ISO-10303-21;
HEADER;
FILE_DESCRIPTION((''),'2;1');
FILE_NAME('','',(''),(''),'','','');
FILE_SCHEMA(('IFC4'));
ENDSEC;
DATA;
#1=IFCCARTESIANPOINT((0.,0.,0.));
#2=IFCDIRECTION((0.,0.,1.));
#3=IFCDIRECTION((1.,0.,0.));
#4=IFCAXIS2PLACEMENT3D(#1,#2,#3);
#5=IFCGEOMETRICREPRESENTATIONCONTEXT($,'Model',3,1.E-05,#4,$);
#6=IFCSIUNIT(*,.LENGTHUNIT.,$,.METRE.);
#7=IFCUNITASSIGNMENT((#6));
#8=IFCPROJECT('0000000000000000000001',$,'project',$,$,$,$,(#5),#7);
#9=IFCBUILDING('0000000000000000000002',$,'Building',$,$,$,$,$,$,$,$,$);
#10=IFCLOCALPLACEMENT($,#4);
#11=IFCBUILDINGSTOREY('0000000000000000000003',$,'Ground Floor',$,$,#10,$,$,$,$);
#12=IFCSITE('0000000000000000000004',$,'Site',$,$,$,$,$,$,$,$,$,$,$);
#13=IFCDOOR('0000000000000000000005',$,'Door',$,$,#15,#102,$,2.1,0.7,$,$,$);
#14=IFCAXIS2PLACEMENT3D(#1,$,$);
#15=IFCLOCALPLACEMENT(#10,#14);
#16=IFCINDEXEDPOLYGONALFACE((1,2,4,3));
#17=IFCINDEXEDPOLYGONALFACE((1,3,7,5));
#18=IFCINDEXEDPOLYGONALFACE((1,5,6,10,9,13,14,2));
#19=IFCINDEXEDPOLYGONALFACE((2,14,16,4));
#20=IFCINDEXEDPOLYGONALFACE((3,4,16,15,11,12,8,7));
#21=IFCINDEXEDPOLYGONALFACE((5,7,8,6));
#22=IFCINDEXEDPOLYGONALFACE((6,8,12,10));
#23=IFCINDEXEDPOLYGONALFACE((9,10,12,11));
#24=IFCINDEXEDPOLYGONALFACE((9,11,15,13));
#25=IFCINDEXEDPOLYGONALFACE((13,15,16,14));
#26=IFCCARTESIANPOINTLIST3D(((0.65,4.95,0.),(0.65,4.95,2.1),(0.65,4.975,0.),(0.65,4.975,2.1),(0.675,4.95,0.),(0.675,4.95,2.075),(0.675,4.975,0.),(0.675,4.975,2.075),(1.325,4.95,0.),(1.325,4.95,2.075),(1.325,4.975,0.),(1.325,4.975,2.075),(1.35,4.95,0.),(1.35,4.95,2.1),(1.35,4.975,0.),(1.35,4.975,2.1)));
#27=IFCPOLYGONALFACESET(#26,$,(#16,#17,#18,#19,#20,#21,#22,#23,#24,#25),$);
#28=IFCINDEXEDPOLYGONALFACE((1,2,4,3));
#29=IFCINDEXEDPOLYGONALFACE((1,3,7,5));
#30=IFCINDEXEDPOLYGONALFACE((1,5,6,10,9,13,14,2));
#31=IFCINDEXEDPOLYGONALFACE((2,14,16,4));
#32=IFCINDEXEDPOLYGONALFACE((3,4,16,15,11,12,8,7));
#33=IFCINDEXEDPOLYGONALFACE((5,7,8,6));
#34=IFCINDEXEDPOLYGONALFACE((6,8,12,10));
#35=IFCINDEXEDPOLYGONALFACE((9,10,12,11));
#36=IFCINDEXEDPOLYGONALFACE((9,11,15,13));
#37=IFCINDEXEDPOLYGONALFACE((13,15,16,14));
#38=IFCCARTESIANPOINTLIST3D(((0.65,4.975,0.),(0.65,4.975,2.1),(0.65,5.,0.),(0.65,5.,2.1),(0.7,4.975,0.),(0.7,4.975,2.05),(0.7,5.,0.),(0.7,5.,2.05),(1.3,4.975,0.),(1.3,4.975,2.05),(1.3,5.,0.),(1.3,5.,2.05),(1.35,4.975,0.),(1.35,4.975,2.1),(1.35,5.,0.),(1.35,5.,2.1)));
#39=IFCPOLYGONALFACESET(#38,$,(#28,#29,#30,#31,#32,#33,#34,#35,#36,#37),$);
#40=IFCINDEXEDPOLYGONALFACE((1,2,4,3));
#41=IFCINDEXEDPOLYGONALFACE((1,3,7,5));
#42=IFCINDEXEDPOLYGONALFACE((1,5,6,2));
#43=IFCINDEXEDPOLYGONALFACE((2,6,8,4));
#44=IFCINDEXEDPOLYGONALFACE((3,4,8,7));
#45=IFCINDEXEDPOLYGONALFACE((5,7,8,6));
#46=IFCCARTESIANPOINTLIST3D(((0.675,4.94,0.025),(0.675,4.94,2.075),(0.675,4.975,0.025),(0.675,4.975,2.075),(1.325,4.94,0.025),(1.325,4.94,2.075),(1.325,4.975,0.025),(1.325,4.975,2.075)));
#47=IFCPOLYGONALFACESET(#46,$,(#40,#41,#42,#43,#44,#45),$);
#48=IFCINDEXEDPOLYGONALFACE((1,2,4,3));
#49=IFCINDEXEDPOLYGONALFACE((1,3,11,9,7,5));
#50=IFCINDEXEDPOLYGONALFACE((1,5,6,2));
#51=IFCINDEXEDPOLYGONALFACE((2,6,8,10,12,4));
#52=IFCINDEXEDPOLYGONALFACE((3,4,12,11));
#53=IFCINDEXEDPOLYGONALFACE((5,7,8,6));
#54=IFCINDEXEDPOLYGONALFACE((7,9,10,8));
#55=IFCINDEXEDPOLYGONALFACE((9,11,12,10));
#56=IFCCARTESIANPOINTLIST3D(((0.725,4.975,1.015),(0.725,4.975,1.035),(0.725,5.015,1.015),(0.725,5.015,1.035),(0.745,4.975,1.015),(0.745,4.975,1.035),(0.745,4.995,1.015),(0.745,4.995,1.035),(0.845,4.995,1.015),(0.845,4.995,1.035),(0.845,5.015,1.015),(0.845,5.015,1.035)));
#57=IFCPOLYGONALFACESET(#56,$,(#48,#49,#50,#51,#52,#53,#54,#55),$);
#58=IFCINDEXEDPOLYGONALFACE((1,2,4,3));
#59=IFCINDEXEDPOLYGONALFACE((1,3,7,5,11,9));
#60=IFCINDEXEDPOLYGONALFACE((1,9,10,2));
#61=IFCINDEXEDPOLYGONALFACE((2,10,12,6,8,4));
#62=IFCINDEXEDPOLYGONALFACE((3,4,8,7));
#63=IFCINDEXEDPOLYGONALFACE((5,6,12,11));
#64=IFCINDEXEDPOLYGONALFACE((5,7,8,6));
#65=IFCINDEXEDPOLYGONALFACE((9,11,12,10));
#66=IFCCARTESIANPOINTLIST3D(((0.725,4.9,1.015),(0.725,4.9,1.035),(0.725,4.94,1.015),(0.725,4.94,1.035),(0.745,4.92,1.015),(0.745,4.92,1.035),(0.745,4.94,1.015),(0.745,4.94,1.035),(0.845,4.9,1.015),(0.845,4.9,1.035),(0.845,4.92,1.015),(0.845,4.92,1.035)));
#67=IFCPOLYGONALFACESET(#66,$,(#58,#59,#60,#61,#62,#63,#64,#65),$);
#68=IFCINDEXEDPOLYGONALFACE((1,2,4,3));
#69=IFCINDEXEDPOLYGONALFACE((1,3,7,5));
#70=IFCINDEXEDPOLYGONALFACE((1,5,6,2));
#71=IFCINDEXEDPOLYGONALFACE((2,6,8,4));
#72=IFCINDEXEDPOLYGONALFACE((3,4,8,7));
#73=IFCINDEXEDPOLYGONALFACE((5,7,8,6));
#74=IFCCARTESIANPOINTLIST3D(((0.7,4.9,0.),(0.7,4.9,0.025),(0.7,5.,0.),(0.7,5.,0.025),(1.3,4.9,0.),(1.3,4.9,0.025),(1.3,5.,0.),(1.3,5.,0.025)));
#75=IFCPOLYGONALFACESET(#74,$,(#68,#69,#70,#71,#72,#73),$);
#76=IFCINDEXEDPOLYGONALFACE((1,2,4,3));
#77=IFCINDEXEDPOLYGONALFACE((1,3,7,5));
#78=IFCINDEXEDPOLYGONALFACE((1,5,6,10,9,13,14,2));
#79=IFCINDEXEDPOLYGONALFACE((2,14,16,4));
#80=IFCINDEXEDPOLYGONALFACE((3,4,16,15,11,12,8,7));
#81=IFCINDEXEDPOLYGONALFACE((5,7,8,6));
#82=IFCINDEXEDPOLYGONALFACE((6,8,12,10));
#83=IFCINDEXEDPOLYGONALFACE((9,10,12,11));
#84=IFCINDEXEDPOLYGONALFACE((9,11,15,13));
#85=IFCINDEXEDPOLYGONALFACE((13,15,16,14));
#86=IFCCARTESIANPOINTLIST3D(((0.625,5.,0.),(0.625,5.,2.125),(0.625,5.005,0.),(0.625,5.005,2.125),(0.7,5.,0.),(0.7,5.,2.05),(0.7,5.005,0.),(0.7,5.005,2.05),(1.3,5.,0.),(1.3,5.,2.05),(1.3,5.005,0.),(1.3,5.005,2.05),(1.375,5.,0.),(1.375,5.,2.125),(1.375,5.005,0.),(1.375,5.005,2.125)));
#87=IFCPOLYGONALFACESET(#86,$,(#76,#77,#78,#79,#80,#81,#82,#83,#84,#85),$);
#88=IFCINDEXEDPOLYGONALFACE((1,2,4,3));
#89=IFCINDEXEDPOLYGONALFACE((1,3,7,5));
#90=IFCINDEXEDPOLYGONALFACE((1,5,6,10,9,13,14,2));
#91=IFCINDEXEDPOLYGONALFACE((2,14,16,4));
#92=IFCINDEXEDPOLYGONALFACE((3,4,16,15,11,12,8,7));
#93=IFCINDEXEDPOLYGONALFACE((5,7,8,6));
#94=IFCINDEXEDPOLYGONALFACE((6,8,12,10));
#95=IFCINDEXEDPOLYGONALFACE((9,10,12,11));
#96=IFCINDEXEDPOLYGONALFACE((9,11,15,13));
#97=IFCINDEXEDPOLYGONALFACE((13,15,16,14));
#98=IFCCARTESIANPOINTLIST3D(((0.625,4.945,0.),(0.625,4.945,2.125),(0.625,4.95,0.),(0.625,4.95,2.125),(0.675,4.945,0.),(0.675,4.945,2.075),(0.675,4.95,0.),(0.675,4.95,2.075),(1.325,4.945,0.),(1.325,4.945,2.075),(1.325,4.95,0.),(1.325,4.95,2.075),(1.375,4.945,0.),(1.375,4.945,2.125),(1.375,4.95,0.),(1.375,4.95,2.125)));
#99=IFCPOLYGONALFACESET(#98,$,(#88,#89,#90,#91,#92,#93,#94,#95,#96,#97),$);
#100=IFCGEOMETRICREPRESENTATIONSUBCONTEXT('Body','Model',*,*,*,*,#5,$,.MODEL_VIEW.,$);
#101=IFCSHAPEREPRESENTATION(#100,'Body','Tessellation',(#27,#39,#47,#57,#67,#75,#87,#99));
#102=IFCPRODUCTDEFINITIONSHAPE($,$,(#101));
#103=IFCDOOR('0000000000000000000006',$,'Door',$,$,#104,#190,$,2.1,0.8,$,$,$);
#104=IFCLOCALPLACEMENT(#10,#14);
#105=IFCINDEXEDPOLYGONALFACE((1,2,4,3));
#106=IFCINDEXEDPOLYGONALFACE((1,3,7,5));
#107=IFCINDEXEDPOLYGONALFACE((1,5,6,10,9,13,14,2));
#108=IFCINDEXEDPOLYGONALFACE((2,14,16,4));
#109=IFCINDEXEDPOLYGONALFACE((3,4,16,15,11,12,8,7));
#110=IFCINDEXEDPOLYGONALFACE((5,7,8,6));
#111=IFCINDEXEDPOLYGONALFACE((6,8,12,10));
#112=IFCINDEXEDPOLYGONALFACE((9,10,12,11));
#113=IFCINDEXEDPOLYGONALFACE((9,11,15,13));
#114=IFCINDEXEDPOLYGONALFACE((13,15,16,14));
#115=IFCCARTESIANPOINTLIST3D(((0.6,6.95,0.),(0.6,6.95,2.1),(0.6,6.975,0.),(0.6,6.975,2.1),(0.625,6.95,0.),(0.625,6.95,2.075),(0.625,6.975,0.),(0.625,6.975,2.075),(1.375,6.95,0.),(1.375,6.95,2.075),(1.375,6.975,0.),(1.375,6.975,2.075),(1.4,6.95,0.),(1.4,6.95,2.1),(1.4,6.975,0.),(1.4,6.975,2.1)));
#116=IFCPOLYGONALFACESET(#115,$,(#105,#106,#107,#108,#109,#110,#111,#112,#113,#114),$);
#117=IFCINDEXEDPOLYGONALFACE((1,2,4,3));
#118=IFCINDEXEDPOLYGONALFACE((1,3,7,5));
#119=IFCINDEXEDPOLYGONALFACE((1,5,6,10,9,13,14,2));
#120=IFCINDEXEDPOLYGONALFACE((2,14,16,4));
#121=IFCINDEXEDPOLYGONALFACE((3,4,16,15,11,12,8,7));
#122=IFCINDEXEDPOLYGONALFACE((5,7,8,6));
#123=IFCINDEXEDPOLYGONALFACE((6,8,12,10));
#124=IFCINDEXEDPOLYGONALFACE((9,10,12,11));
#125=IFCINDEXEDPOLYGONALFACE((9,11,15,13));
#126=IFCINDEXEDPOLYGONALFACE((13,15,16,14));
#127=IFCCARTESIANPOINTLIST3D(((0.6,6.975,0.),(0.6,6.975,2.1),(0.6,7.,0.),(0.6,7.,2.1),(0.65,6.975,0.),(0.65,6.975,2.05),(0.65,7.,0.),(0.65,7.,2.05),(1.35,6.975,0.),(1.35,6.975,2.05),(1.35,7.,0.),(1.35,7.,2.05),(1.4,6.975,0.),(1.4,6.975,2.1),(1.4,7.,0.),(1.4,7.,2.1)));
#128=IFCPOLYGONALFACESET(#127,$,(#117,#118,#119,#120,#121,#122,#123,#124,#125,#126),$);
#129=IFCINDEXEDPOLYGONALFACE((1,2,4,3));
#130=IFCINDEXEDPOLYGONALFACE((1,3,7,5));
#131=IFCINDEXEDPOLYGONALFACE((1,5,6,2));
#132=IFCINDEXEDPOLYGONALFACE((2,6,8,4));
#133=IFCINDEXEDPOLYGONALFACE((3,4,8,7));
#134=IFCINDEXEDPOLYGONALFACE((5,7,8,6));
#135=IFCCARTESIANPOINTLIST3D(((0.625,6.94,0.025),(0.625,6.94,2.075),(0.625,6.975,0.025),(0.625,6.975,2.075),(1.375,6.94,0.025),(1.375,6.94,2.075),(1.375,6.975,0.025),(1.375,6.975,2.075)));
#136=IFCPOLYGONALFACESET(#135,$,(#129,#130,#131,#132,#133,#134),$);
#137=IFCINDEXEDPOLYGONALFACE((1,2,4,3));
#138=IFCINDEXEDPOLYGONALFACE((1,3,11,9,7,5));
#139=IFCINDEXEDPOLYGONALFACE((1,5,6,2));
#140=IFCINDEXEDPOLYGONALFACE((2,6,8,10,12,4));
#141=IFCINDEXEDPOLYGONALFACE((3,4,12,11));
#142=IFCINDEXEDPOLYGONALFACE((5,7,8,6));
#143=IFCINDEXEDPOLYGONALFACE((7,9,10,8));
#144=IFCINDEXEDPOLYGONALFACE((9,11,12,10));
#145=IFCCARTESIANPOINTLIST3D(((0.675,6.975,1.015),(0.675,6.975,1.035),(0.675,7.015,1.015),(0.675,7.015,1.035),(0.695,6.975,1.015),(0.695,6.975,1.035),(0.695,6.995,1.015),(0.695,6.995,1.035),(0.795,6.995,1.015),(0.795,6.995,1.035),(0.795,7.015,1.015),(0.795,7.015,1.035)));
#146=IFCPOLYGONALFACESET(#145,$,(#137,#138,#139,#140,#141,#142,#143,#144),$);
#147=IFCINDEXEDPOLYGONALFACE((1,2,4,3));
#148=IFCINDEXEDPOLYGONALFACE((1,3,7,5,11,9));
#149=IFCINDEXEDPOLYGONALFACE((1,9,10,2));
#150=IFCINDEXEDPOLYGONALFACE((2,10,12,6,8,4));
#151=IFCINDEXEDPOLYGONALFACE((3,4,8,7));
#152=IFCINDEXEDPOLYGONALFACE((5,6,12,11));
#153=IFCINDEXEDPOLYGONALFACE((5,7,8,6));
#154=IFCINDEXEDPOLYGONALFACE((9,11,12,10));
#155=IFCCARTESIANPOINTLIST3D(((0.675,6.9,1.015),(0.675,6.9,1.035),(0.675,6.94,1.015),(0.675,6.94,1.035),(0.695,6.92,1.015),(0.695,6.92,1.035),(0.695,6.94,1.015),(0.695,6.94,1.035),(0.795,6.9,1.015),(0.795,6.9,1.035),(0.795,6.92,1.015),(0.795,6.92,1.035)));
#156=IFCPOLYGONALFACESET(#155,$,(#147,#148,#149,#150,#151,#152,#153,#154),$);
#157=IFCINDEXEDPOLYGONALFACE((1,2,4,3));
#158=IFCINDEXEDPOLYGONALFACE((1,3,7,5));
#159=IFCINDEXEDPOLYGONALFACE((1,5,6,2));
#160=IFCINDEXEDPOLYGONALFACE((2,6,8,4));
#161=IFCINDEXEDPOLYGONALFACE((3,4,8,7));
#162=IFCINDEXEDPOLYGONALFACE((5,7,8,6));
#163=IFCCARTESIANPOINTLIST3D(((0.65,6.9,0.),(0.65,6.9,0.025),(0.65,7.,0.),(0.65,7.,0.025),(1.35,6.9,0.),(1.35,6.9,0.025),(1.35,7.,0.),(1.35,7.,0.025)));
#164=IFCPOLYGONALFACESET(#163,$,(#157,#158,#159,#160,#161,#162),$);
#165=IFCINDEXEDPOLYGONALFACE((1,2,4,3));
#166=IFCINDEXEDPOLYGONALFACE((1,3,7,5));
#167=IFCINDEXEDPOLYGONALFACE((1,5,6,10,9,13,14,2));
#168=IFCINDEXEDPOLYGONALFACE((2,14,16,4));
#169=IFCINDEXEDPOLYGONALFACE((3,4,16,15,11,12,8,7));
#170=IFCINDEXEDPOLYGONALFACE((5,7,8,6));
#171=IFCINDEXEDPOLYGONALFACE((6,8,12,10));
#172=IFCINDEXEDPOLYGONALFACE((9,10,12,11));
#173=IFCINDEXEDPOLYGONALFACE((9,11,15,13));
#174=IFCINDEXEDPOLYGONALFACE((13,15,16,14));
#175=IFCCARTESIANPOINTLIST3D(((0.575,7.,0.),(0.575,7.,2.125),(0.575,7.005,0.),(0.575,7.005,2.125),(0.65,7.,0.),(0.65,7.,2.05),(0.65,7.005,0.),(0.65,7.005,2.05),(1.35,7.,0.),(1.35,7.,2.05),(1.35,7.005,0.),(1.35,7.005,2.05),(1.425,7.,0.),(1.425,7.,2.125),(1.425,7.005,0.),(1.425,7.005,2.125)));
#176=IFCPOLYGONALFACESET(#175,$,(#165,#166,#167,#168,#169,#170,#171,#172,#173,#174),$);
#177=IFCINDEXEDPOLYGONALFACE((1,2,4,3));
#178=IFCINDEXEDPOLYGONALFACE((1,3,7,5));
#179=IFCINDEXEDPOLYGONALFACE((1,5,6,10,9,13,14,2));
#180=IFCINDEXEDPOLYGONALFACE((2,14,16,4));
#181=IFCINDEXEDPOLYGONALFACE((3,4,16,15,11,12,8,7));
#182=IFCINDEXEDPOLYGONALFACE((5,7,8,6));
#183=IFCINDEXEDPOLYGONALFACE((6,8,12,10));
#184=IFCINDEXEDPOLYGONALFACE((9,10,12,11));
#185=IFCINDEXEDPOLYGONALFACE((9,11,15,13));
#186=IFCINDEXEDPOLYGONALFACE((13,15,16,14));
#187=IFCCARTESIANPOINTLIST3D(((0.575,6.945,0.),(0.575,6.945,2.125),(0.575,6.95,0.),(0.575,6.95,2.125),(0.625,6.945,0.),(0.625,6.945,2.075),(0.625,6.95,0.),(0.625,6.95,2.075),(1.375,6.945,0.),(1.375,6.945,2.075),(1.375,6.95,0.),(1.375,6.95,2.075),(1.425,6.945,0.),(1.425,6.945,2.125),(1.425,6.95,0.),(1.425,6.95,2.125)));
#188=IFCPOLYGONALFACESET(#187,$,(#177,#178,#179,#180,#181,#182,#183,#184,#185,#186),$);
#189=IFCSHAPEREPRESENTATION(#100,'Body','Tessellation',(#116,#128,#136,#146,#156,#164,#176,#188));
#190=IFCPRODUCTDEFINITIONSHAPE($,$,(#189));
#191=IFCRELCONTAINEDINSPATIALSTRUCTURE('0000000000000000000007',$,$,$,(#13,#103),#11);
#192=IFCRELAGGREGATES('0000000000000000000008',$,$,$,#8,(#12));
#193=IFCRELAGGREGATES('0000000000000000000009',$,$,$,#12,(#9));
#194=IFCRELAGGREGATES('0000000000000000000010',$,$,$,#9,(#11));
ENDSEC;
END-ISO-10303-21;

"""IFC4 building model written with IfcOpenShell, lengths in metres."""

from ifc_helpers import new_model, si_unit, frame, origin_with_axes, place, context, subcontext, project, spatial, line, indexed_curve, outline, extrude, element, save


model = new_model("IFC4")

# Units and contexts
model_context = context("Model", 3, precision=1e-05, world=origin_with_axes())
body_context = subcontext(model_context, "Body", "Model", "MODEL_VIEW")
ifc_project = project(units=[si_unit("LENGTHUNIT", "METRE")], contexts=[model_context])

# Site, building, storey
site = spatial("IfcSite", under=ifc_project, Name="Site")
building = spatial("IfcBuilding", under=site, Name="Building")
storey_placement = place(None, origin_with_axes())
storey = spatial("IfcBuildingStorey", under=building, at=storey_placement, Name="Ground Floor")

# Doors
door_1_placement = place(storey_placement, frame((1.35, 5.0, 0.0), z_axis=(0.0, 0.0, 1.0), x_axis=(-1.0, 0.0, 0.0)))
element("IfcDoor", 1, at=door_1_placement, inside=storey, Name="Door", OverallHeight=2.1, OverallWidth=0.7, context=body_context, shape_type="SweptSolid", body=[
    extrude(outline(indexed_curve([(0.0, 0.0), (0.0, 2.1), (0.7, 2.1), (0.7, 0.0), (0.675, 0.0), (0.675, 2.075), (0.025, 2.075), (0.025, 0.0)], segments=[line(1, 2, 3, 4, 5, 6, 7, 8, 1)])), frame((0.0, 0.025, 0.0), z_axis=(0.0, -1.0, 0.0), x_axis=(1.0, 0.0, 0.0)), (0.0, 0.0, -1.0), 0.025),
    extrude(outline(indexed_curve([(0.0, 0.0), (0.0, 2.1), (0.7, 2.1), (0.7, 0.0), (0.65, 0.0), (0.65, 2.05), (0.05, 2.05), (0.05, 0.0)], segments=[line(1, 2, 3, 4, 5, 6, 7, 8, 1)])), frame((0.0, 0.0, 0.0), z_axis=(0.0, -1.0, 0.0), x_axis=(1.0, 0.0, 0.0)), (0.0, 0.0, -1.0), 0.025),
    extrude(outline(indexed_curve([(0.0, 0.0), (0.65, 0.0), (0.65, 0.035), (0.0, 0.035)], segments=[line(1, 2, 3, 4, 1)])), frame((0.025, 0.025, 0.025), z_axis=(0.0, 0.0, 1.0), x_axis=(1.0, 0.0, 0.0)), (0.0, 0.0, 1.0), 2.05),
    extrude(outline(indexed_curve([(0.0, 0.0), (0.0, -0.04), (-0.12, -0.04), (-0.12, -0.02), (-0.02, -0.02), (-0.02, 0.0)], segments=[line(1, 2, 3, 4, 5, 6, 1)])), frame((0.625, 0.025, 1.015), z_axis=(0.0, 0.0, 1.0), x_axis=(1.0, 0.0, 0.0)), (0.0, 0.0, 1.0), 0.02),
    extrude(outline(indexed_curve([(0.0, 0.0), (0.0, 0.04), (-0.12, 0.04), (-0.12, 0.02), (-0.02, 0.02), (-0.02, 0.0)], segments=[line(1, 2, 3, 4, 5, 6, 1)])), frame((0.625, 0.06, 1.015), z_axis=(0.0, 0.0, 1.0), x_axis=(1.0, 0.0, 0.0)), (0.0, 0.0, 1.0), 0.02),
    extrude(outline(indexed_curve([(0.0, 0.0), (0.6, 0.0), (0.6, 0.1), (0.0, 0.1)], segments=[line(1, 2, 3, 4, 1)])), frame((0.05, 0.0, 0.0), z_axis=(0.0, 0.0, 1.0), x_axis=(1.0, 0.0, 0.0)), (0.0, 0.0, 1.0), 0.025),
    extrude(outline(indexed_curve([(0.0, 0.0), (0.0, 2.125), (0.75, 2.125), (0.75, 0.0), (0.675, 0.0), (0.675, 2.05), (0.075, 2.05), (0.075, 0.0)], segments=[line(1, 2, 3, 4, 5, 6, 7, 8, 1)])), frame((-0.025, -0.005, 0.0), z_axis=(0.0, -1.0, 0.0), x_axis=(1.0, 0.0, 0.0)), (0.0, 0.0, -1.0), 0.005),
    extrude(outline(indexed_curve([(0.0, 0.0), (0.0, 2.125), (0.75, 2.125), (0.75, 0.0), (0.7, 0.0), (0.7, 2.075), (0.05, 2.075), (0.05, 0.0)], segments=[line(1, 2, 3, 4, 5, 6, 7, 8, 1)])), frame((-0.025, 0.05, 0.0), z_axis=(0.0, -1.0, 0.0), x_axis=(1.0, 0.0, 0.0)), (0.0, 0.0, -1.0), 0.005),
])
door_2_placement = place(storey_placement, frame((1.4, 7.0, 0.0), z_axis=(0.0, 0.0, 1.0), x_axis=(-1.0, 0.0, 0.0)))
element("IfcDoor", 2, at=door_2_placement, inside=storey, Name="Door", OverallHeight=2.1, OverallWidth=0.8, context=body_context, shape_type="SweptSolid", body=[
    extrude(outline(indexed_curve([(0.0, 0.0), (0.0, 2.1), (0.8, 2.1), (0.8, 0.0), (0.775, 0.0), (0.775, 2.075), (0.025, 2.075), (0.025, 0.0)], segments=[line(1, 2, 3, 4, 5, 6, 7, 8, 1)])), frame((0.0, 0.025, 0.0), z_axis=(0.0, -1.0, 0.0), x_axis=(1.0, 0.0, 0.0)), (0.0, 0.0, -1.0), 0.025),
    extrude(outline(indexed_curve([(0.0, 0.0), (0.0, 2.1), (0.8, 2.1), (0.8, 0.0), (0.75, 0.0), (0.75, 2.05), (0.05, 2.05), (0.05, 0.0)], segments=[line(1, 2, 3, 4, 5, 6, 7, 8, 1)])), frame((0.0, 0.0, 0.0), z_axis=(0.0, -1.0, 0.0), x_axis=(1.0, 0.0, 0.0)), (0.0, 0.0, -1.0), 0.025),
    extrude(outline(indexed_curve([(0.0, 0.0), (0.75, 0.0), (0.75, 0.035), (0.0, 0.035)], segments=[line(1, 2, 3, 4, 1)])), frame((0.025, 0.025, 0.025), z_axis=(0.0, 0.0, 1.0), x_axis=(1.0, 0.0, 0.0)), (0.0, 0.0, 1.0), 2.05),
    extrude(outline(indexed_curve([(0.0, 0.0), (0.0, -0.04), (-0.12, -0.04), (-0.12, -0.02), (-0.02, -0.02), (-0.02, 0.0)], segments=[line(1, 2, 3, 4, 5, 6, 1)])), frame((0.725, 0.025, 1.015), z_axis=(0.0, 0.0, 1.0), x_axis=(1.0, 0.0, 0.0)), (0.0, 0.0, 1.0), 0.02),
    extrude(outline(indexed_curve([(0.0, 0.0), (0.0, 0.04), (-0.12, 0.04), (-0.12, 0.02), (-0.02, 0.02), (-0.02, 0.0)], segments=[line(1, 2, 3, 4, 5, 6, 1)])), frame((0.725, 0.06, 1.015), z_axis=(0.0, 0.0, 1.0), x_axis=(1.0, 0.0, 0.0)), (0.0, 0.0, 1.0), 0.02),
    extrude(outline(indexed_curve([(0.0, 0.0), (0.7, 0.0), (0.7, 0.1), (0.0, 0.1)], segments=[line(1, 2, 3, 4, 1)])), frame((0.05, 0.0, 0.0), z_axis=(0.0, 0.0, 1.0), x_axis=(1.0, 0.0, 0.0)), (0.0, 0.0, 1.0), 0.025),
    extrude(outline(indexed_curve([(0.0, 0.0), (0.0, 2.125), (0.85, 2.125), (0.85, 0.0), (0.775, 0.0), (0.775, 2.05), (0.075, 2.05), (0.075, 0.0)], segments=[line(1, 2, 3, 4, 5, 6, 7, 8, 1)])), frame((-0.025, -0.005, 0.0), z_axis=(0.0, -1.0, 0.0), x_axis=(1.0, 0.0, 0.0)), (0.0, 0.0, -1.0), 0.005),
    extrude(outline(indexed_curve([(0.0, 0.0), (0.0, 2.125), (0.85, 2.125), (0.85, 0.0), (0.8, 0.0), (0.8, 2.075), (0.05, 2.075), (0.05, 0.0)], segments=[line(1, 2, 3, 4, 5, 6, 7, 8, 1)])), frame((-0.025, 0.05, 0.0), z_axis=(0.0, -1.0, 0.0), x_axis=(1.0, 0.0, 0.0)), (0.0, 0.0, -1.0), 0.005),
])

save(model, "model.ifc")
